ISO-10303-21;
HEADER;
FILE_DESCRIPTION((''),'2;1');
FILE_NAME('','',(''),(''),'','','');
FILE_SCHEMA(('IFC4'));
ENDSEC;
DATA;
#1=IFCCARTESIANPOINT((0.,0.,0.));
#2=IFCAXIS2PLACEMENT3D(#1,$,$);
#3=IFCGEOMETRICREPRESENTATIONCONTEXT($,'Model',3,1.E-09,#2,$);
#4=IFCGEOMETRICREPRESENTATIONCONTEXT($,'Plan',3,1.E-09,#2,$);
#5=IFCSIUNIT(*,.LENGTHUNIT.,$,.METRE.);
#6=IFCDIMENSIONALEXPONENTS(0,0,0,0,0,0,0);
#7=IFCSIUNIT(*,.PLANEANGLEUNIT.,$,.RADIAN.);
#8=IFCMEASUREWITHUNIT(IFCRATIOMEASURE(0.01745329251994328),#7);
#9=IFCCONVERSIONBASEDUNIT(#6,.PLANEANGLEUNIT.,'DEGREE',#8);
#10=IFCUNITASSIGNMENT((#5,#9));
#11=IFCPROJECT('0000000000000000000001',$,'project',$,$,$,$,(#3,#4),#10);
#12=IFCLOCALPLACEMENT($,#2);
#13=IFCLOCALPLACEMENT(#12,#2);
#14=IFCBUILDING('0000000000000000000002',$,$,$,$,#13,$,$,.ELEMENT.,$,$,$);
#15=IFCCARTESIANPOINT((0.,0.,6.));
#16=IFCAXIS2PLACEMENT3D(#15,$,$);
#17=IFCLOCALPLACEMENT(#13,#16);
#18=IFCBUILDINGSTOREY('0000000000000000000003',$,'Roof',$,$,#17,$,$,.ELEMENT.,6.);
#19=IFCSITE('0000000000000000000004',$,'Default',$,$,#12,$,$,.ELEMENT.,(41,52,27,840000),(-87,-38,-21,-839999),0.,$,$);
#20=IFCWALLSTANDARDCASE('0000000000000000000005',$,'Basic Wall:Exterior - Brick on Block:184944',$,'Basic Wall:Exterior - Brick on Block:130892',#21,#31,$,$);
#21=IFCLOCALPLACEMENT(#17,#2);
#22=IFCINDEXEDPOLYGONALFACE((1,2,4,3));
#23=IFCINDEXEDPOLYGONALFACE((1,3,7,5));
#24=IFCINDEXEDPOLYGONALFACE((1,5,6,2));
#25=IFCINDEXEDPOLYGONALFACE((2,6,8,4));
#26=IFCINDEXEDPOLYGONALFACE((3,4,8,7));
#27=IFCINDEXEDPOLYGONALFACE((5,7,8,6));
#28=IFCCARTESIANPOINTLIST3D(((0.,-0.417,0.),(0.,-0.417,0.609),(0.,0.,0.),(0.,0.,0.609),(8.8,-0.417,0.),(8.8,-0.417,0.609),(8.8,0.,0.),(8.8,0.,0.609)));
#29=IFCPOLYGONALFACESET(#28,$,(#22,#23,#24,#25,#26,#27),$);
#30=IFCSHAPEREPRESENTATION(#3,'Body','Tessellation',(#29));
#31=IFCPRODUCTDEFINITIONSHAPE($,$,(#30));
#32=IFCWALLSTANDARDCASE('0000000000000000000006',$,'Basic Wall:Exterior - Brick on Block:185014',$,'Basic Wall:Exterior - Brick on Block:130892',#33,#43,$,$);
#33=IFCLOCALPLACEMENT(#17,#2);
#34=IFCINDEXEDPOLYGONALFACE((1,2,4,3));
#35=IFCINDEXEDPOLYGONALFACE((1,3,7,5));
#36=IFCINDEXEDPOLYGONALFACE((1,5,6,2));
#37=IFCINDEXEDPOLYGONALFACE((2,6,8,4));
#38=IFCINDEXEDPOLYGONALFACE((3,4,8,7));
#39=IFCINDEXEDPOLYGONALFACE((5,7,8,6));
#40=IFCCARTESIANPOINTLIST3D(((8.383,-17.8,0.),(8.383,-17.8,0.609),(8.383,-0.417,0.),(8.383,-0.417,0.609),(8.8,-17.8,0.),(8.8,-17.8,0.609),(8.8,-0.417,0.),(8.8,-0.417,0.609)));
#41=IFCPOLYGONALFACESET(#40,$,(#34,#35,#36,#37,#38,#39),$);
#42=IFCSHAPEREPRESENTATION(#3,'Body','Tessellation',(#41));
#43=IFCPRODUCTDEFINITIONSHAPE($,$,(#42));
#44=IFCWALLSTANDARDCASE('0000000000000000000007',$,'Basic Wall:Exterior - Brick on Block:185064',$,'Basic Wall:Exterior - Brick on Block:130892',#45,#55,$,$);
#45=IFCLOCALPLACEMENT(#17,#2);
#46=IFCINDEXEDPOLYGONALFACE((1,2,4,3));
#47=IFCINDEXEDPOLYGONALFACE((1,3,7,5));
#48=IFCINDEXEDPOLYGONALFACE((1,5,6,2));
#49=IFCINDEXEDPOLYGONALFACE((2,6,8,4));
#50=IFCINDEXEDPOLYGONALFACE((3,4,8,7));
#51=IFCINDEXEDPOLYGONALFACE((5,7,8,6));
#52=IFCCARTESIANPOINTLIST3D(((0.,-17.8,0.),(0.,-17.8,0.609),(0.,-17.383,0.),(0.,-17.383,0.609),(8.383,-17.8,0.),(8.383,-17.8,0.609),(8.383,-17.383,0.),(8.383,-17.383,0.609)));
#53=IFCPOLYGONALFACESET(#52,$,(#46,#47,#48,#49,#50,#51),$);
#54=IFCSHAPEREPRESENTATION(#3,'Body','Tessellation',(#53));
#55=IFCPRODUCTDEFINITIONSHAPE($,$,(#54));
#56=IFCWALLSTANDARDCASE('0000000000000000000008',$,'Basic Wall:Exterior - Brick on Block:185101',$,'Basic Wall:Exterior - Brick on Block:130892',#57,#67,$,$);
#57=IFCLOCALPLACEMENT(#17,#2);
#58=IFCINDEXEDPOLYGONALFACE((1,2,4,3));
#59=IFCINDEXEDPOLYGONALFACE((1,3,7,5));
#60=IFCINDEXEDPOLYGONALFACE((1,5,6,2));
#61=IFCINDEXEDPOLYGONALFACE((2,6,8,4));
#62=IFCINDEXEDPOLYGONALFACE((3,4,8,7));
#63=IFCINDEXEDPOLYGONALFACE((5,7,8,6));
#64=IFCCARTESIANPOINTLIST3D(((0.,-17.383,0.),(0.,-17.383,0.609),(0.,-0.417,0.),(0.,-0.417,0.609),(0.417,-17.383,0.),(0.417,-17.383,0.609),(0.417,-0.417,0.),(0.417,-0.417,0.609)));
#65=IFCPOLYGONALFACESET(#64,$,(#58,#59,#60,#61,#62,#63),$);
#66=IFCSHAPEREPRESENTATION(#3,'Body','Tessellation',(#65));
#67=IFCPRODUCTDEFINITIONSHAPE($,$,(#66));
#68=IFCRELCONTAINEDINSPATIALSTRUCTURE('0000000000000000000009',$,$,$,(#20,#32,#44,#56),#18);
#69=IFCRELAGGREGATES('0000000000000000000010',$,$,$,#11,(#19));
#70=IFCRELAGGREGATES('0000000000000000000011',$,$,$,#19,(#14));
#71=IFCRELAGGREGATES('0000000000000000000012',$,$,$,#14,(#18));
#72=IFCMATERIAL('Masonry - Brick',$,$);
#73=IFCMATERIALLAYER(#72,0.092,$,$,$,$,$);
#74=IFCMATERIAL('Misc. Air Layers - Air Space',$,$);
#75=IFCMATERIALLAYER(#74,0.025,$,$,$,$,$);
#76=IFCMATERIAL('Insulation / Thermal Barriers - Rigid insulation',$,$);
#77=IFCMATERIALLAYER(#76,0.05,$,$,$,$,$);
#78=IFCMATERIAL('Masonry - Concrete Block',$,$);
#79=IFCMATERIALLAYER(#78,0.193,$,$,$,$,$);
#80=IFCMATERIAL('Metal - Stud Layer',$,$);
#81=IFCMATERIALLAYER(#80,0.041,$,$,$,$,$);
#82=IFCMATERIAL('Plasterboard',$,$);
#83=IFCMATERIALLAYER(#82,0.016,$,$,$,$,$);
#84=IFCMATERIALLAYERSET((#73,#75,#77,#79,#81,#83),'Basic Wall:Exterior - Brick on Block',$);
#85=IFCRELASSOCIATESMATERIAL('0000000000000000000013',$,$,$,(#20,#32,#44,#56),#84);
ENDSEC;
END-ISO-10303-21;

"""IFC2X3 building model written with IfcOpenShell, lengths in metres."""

from ifc_helpers import new_model, entity, si_unit, converted_unit, frame, frame_2d, origin, place, context, project, spatial, rectangle, extrude, material, layer, layer_set, layer_usage, element, save


model = new_model("IFC2X3")

# Units and contexts
model_context = context("Model", 3, precision=1e-09, world=origin())
plan_context = context("Plan", 3, precision=1e-09, world=origin())
ifc_project = project(units=[si_unit("LENGTHUNIT", "METRE"), converted_unit("PLANEANGLEUNIT", "DEGREE", entity("IfcRatioMeasure", 0.01745329251994328), si_unit("PLANEANGLEUNIT", "RADIAN"), dimensions=[0, 0, 0, 0, 0, 0, 0])], contexts=[model_context, plan_context])

# Site, building, storey
site_placement = place(None, origin())
site = spatial("IfcSite", under=ifc_project, at=site_placement, Name="Default", CompositionType="ELEMENT", RefLatitude=(41, 52, 27, 840000), RefLongitude=(-87, -38, -21, -839999), RefElevation=0.0)
building_placement = place(site_placement, origin())
building = spatial("IfcBuilding", under=site, at=building_placement, CompositionType="ELEMENT")
storey_placement = place(building_placement, frame((0.0, 0.0, 6.0)))
storey = spatial("IfcBuildingStorey", under=building, at=storey_placement, Name="Roof", CompositionType="ELEMENT", Elevation=6.0)

# Walls
ifc_material_1 = material(Name="Masonry - Brick")
ifc_layer_1 = layer(ifc_material_1, 0.092)
ifc_material_2 = material(Name="Misc. Air Layers - Air Space")
ifc_layer_2 = layer(ifc_material_2, 0.025)
ifc_material_3 = material(Name="Insulation / Thermal Barriers - Rigid insulation")
ifc_layer_3 = layer(ifc_material_3, 0.05)
ifc_material_4 = material(Name="Masonry - Concrete Block")
ifc_layer_4 = layer(ifc_material_4, 0.193)
ifc_material_5 = material(Name="Metal - Stud Layer")
ifc_layer_5 = layer(ifc_material_5, 0.041)
ifc_material_6 = material(Name="Plasterboard")
ifc_layer_6 = layer(ifc_material_6, 0.016)
ifc_layer_set = layer_set([ifc_layer_1, ifc_layer_2, ifc_layer_3, ifc_layer_4, ifc_layer_5, ifc_layer_6], Name="Basic Wall:Exterior - Brick on Block")
ifc_layer_usage = layer_usage(ifc_layer_set, "AXIS2", "NEGATIVE", 0.2085)
wall_1_placement = place(storey_placement, frame((0.0, -0.2085, 0.0)))
element("IfcWallStandardCase", 1, at=wall_1_placement, inside=storey, material=ifc_layer_usage, Name="Basic Wall:Exterior - Brick on Block:184944", ObjectType="Basic Wall:Exterior - Brick on Block:130892", context=model_context, shape_type="SweptSolid", body=[
    extrude(rectangle(XDim=8.8, YDim=0.417, at=frame_2d((4.4, 0.0), x_axis=(-1.0, 0.0))), origin(), (0.0, 0.0, 1.0), 0.609),
])
wall_2_placement = place(storey_placement, frame((8.5915, -0.417, 0.0), z_axis=(0.0, 0.0, 1.0), x_axis=(0.0, -1.0, 0.0)))
element("IfcWallStandardCase", 2, at=wall_2_placement, inside=storey, material=ifc_layer_usage, Name="Basic Wall:Exterior - Brick on Block:185014", ObjectType="Basic Wall:Exterior - Brick on Block:130892", context=model_context, shape_type="SweptSolid", body=[
    extrude(rectangle(XDim=17.383, YDim=0.417, at=frame_2d((8.6915, 0.0), x_axis=(-1.0, 0.0))), origin(), (0.0, 0.0, 1.0), 0.609),
])
wall_3_placement = place(storey_placement, frame((8.383, -17.5915, 0.0), z_axis=(0.0, 0.0, 1.0), x_axis=(-1.0, 0.0, 0.0)))
element("IfcWallStandardCase", 3, at=wall_3_placement, inside=storey, material=ifc_layer_usage, Name="Basic Wall:Exterior - Brick on Block:185064", ObjectType="Basic Wall:Exterior - Brick on Block:130892", context=model_context, shape_type="SweptSolid", body=[
    extrude(rectangle(XDim=8.383, YDim=0.417, at=frame_2d((4.1915, 0.0), x_axis=(-1.0, 0.0))), origin(), (0.0, 0.0, 1.0), 0.609),
])
wall_4_placement = place(storey_placement, frame((0.2085, -17.383, 0.0), z_axis=(0.0, 0.0, 1.0), x_axis=(0.0, 1.0, 0.0)))
element("IfcWallStandardCase", 4, at=wall_4_placement, inside=storey, material=ifc_layer_usage, Name="Basic Wall:Exterior - Brick on Block:185101", ObjectType="Basic Wall:Exterior - Brick on Block:130892", context=model_context, shape_type="SweptSolid", body=[
    extrude(rectangle(XDim=16.966, YDim=0.417, at=frame_2d((8.483, 0.0), x_axis=(-1.0, 0.0))), origin(), (0.0, 0.0, 1.0), 0.609),
])

save(model, "model.ifc")
